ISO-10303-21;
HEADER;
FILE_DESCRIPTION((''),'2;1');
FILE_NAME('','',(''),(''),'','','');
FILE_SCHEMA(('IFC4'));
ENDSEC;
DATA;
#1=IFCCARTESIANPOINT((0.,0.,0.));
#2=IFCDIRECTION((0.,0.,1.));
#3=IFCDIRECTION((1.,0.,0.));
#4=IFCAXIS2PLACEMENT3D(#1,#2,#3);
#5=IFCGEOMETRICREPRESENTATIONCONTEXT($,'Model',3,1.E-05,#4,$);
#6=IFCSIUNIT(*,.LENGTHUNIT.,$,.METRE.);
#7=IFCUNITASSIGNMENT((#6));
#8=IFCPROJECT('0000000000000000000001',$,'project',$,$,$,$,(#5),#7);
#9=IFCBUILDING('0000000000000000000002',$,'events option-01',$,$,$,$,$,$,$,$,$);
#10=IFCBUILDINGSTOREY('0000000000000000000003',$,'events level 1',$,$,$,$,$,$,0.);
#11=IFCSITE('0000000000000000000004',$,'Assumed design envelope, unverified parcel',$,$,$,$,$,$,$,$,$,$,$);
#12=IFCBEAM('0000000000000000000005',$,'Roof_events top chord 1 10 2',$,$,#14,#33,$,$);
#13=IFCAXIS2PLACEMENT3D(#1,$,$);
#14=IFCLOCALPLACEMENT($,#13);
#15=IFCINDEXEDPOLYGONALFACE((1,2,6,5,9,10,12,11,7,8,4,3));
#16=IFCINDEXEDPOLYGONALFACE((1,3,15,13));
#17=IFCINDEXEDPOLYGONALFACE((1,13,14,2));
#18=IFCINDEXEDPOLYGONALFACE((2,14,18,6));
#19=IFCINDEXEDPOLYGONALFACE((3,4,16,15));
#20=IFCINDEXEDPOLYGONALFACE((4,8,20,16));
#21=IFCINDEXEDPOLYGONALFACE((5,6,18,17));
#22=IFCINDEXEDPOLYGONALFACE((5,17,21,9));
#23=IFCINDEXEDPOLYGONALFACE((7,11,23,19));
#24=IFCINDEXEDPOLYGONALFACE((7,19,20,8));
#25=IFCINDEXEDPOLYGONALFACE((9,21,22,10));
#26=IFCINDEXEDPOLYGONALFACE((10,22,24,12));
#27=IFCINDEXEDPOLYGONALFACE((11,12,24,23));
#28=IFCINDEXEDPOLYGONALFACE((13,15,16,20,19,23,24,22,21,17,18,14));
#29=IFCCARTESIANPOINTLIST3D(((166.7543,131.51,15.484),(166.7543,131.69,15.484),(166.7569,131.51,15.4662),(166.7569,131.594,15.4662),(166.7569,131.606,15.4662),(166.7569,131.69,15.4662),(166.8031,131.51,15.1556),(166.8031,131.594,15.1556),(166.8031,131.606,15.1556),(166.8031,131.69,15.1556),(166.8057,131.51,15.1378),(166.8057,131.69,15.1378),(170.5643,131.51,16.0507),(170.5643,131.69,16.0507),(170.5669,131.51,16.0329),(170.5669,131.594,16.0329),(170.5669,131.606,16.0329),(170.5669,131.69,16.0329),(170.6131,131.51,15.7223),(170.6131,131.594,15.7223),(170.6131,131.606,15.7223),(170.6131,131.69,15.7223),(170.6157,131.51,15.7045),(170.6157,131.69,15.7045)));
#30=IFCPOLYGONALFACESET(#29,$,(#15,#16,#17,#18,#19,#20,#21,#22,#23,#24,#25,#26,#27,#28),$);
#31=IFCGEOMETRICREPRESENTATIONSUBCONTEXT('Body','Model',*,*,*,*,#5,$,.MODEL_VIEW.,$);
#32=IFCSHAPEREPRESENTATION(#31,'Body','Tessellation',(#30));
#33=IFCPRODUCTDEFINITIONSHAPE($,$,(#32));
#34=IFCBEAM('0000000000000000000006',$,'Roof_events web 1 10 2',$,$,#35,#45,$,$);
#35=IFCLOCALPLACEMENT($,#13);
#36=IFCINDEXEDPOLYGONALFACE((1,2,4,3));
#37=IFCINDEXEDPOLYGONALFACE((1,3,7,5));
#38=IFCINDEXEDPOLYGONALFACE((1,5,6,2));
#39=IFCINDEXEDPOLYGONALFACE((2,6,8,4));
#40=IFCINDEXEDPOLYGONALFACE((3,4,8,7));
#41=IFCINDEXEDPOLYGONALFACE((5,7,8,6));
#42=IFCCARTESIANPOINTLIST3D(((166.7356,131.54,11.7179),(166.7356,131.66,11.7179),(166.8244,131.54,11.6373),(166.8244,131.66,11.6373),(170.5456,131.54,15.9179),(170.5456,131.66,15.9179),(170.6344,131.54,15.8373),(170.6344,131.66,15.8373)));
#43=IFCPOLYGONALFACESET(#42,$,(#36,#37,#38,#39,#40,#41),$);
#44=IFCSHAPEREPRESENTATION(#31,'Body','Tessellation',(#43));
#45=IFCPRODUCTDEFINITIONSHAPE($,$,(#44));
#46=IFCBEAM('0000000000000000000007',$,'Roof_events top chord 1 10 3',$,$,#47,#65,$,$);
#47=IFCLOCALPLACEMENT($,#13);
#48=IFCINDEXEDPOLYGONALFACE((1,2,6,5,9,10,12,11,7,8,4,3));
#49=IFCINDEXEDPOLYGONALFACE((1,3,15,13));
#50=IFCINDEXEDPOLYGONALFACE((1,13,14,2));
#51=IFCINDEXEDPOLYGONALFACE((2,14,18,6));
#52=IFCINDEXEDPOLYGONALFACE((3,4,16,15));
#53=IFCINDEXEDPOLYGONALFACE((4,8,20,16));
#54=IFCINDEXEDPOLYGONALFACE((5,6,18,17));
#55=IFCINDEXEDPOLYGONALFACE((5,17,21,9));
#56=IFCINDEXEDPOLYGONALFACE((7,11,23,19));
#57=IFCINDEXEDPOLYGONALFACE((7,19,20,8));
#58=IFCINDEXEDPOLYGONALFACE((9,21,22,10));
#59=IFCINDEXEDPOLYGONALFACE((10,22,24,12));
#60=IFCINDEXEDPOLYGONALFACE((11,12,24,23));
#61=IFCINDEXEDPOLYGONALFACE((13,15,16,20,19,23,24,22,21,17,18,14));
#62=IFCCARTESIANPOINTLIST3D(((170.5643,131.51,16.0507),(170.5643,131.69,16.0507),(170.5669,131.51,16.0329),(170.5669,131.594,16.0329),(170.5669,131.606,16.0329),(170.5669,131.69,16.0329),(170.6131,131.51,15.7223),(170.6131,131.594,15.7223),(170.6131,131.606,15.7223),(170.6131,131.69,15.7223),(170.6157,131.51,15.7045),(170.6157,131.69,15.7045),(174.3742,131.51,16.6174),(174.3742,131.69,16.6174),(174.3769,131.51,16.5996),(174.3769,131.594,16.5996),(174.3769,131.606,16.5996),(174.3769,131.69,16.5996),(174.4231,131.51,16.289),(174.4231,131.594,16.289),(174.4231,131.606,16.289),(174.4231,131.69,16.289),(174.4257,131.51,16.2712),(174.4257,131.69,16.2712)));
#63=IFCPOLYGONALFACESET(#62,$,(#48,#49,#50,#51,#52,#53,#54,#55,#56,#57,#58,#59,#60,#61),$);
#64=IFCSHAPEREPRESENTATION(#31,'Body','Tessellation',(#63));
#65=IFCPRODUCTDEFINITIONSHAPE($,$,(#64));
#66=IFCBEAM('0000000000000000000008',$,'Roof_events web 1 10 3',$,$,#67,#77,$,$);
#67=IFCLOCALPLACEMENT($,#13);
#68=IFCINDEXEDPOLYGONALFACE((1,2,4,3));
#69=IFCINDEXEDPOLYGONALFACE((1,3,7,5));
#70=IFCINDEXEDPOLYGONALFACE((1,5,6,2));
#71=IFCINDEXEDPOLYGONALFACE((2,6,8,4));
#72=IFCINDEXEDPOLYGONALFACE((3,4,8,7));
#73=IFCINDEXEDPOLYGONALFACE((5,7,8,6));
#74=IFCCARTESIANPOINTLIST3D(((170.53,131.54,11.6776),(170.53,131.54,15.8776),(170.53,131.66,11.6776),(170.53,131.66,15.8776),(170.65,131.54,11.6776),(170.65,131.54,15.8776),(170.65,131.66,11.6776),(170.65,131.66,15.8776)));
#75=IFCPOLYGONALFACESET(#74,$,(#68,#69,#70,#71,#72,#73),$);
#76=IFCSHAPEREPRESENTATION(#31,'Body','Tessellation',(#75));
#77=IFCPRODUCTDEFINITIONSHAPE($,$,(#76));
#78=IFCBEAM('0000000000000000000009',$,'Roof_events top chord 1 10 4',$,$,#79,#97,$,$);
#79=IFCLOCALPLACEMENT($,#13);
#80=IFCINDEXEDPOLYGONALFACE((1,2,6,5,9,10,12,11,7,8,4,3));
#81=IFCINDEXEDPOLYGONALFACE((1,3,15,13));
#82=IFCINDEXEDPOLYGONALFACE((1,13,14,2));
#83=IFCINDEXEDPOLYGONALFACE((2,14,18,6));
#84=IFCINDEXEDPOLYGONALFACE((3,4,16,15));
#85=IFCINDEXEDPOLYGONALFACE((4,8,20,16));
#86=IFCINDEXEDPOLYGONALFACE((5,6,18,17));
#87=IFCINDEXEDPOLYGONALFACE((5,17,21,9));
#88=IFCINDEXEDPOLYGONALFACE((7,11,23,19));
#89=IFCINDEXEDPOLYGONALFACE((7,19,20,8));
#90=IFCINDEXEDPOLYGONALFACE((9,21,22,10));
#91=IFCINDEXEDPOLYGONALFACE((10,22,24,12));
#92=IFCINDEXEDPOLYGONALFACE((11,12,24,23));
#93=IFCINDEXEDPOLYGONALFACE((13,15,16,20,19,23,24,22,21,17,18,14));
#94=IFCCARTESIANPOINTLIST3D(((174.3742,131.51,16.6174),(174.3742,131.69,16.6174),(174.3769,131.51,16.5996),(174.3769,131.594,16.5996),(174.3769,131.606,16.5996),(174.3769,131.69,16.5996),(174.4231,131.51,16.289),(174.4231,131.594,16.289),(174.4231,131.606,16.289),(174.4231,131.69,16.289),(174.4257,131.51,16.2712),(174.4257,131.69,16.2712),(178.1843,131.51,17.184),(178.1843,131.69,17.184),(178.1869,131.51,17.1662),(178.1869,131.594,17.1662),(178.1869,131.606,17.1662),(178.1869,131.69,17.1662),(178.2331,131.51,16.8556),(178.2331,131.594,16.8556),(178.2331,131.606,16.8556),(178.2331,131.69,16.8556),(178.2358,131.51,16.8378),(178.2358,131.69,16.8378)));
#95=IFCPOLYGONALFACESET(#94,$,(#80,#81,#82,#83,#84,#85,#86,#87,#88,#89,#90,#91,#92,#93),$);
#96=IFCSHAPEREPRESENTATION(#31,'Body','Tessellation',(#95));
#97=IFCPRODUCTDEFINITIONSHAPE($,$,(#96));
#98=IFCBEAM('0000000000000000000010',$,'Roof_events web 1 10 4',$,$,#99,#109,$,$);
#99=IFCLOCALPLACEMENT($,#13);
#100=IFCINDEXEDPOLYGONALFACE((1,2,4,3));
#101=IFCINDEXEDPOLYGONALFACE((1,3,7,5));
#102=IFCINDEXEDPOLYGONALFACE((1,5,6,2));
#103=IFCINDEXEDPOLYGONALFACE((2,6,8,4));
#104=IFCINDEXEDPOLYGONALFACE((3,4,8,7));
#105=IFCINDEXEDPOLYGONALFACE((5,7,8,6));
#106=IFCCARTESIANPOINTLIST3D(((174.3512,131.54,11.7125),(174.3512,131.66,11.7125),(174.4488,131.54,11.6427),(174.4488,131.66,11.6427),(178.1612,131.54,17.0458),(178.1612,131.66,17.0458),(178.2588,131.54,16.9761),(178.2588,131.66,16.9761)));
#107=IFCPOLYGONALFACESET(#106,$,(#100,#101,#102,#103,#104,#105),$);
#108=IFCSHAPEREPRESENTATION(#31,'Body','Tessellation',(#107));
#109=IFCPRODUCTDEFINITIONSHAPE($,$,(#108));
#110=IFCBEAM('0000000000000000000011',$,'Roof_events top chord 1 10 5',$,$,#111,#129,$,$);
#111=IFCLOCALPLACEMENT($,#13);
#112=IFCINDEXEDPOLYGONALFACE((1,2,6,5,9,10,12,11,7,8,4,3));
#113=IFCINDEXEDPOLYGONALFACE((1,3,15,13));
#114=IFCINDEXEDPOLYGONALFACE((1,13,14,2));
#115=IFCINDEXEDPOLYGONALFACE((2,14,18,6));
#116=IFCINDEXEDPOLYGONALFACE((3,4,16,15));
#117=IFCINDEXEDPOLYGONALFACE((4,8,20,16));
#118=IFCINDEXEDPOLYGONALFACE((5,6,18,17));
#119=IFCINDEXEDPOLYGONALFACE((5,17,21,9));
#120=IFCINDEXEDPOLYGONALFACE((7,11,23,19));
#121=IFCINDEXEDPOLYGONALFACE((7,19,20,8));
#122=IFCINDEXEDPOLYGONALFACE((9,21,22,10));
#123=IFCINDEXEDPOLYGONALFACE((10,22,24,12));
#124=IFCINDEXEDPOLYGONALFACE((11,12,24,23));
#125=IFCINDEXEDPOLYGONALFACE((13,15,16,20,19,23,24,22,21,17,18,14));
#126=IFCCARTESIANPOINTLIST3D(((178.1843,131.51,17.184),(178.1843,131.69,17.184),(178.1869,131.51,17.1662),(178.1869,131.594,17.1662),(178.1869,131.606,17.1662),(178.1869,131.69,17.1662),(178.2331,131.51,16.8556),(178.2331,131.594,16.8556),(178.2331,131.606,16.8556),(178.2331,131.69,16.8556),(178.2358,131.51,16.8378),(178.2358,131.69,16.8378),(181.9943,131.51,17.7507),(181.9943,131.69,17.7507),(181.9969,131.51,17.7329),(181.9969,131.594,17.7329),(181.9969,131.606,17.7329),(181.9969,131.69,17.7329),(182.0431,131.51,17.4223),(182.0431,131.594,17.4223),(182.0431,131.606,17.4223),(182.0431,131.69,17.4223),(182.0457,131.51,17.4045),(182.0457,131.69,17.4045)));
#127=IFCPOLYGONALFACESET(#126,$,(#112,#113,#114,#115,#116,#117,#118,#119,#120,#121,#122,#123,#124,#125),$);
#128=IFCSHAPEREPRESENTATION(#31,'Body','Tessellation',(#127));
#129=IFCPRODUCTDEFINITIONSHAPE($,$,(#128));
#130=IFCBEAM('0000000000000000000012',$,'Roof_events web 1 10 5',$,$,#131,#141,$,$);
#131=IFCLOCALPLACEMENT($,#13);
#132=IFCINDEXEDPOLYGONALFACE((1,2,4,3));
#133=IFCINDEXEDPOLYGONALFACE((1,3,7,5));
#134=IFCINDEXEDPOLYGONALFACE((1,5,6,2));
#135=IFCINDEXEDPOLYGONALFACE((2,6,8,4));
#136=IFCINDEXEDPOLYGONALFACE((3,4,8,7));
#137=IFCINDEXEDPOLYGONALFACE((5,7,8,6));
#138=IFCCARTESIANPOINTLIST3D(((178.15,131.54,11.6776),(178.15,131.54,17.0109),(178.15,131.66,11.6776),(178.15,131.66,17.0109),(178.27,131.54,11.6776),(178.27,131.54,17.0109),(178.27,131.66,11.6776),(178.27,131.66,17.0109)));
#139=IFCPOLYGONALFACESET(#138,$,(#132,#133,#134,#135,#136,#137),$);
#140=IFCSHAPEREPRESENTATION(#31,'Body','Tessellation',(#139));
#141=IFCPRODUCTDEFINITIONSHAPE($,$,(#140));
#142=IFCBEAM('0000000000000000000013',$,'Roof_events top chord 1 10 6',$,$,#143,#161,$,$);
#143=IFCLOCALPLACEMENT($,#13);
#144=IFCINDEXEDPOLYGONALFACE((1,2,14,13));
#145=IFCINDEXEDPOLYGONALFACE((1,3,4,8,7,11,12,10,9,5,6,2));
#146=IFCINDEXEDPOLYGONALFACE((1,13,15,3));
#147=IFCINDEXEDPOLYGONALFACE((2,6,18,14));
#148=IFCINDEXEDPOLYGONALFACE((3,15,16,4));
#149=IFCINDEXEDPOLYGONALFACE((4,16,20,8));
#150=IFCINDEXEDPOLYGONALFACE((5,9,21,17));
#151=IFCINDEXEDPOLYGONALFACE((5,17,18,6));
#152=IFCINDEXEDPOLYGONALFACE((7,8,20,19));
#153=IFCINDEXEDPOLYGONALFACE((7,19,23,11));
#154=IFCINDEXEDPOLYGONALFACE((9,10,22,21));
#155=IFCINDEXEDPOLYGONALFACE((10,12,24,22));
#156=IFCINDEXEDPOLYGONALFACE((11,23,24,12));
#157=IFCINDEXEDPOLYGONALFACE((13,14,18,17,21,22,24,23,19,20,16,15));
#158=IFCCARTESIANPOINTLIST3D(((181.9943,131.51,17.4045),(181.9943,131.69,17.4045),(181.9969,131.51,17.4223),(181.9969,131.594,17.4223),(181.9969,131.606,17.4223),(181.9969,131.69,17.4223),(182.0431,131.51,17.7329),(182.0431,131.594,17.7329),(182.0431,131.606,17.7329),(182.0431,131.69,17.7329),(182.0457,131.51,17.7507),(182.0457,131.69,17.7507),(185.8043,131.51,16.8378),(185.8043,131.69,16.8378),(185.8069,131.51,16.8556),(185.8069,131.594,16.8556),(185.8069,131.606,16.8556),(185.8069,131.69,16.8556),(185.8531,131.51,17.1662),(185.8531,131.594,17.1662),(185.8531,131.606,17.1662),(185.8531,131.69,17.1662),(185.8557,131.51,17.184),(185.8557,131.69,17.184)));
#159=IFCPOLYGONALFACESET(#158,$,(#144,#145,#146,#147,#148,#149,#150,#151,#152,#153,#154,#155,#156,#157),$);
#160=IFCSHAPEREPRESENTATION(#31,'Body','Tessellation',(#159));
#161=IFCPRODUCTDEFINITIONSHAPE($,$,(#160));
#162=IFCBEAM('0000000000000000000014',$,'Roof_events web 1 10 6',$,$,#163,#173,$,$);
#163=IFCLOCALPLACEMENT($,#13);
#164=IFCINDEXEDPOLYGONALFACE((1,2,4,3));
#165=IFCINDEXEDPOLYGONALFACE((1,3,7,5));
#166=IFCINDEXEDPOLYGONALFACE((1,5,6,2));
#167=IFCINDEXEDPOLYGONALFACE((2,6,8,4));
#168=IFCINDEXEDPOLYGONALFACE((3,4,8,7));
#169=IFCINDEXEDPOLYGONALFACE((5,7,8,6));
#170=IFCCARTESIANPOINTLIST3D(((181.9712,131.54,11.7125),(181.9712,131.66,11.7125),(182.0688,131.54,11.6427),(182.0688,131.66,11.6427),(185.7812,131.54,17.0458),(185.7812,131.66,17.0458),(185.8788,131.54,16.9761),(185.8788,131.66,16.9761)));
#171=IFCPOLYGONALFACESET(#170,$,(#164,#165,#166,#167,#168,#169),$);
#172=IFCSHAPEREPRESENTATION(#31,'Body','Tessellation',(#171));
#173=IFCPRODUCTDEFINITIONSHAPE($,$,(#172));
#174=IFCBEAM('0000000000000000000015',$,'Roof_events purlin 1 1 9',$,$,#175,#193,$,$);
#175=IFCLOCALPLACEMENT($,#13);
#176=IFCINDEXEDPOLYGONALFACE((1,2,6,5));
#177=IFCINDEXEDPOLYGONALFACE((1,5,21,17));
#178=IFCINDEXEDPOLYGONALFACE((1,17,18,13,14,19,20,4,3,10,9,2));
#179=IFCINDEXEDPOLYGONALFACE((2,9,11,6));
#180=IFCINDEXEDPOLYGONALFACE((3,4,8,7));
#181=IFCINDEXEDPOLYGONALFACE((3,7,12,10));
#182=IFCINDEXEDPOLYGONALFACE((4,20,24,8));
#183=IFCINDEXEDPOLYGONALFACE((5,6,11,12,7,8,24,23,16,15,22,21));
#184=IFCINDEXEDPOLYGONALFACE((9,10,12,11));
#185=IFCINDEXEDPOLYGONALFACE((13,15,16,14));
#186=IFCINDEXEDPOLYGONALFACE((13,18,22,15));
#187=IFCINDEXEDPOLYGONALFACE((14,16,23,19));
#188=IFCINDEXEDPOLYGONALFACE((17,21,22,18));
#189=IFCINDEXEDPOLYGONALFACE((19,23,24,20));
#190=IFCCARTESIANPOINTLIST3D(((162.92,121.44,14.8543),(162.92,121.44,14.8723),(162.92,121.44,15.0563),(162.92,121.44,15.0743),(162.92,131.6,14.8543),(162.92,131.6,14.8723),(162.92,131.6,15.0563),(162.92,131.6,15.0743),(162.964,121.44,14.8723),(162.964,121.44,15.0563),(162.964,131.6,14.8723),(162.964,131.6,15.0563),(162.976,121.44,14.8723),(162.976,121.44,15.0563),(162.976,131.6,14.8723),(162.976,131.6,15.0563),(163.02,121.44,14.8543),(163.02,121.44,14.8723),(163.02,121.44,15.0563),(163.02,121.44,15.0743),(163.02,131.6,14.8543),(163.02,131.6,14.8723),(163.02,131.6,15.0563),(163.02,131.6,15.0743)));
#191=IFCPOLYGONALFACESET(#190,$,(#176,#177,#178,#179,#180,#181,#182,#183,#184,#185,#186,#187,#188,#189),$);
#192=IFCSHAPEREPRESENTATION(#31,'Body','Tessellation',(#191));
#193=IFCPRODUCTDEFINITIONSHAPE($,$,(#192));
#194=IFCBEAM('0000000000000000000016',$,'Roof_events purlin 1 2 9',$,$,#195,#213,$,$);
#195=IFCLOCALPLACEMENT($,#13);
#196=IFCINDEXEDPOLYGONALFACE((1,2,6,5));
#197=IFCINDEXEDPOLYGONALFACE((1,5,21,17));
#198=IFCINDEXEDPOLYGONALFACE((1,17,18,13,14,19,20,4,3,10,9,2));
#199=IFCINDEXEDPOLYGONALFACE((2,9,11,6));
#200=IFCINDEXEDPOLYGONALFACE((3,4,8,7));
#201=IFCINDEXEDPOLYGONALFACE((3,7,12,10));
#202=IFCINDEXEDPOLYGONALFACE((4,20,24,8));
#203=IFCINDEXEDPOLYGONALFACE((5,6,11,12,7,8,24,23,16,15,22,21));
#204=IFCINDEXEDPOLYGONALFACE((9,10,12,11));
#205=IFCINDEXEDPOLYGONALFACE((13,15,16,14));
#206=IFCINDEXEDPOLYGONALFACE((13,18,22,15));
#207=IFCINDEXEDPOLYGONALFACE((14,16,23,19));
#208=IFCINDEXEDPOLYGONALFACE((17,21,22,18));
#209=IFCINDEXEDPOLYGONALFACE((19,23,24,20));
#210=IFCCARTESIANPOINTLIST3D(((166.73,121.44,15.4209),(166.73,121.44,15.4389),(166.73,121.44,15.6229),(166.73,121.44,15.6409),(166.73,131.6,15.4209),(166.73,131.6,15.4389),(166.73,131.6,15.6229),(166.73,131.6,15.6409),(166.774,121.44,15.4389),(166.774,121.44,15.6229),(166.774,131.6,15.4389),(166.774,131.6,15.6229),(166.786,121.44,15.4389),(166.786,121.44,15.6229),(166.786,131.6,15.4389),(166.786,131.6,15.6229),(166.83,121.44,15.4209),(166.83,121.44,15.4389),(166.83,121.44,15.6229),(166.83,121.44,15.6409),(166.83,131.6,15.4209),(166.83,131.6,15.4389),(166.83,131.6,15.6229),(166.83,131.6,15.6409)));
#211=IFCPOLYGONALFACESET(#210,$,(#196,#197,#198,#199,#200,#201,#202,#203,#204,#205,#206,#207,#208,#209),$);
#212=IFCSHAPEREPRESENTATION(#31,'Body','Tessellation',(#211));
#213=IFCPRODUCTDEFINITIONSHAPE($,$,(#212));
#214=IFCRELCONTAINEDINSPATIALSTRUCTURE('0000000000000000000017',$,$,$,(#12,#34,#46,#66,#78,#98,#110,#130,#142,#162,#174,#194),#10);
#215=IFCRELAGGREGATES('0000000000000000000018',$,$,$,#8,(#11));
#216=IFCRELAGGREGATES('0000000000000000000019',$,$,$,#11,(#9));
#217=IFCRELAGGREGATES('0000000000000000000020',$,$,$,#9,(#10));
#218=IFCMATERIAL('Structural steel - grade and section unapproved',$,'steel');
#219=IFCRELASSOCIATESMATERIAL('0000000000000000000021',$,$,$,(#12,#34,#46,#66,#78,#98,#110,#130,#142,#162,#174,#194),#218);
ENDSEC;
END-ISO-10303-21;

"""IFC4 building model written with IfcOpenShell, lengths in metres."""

from ifc_helpers import new_model, si_unit, frame, origin_with_axes, place, context, subcontext, project, spatial, rectangle, i_section, extrude, material, element, save


model = new_model("IFC4")

# Units and contexts
model_context = context("Model", 3, precision=1e-05, world=origin_with_axes())
body_context = subcontext(model_context, "Body", "Model", "MODEL_VIEW")
ifc_project = project(units=[si_unit("LENGTHUNIT", "METRE")], contexts=[model_context])

# Site, building, storey
site = spatial("IfcSite", under=ifc_project, Name="Assumed design envelope, unverified parcel")
building = spatial("IfcBuilding", under=site, Name="events option-01")
storey = spatial("IfcBuildingStorey", under=building, Name="events level 1", Elevation=0.0)

# Beams
ifc_material_1 = material(Name="Structural steel - grade and section unapproved", Category="steel")
beam_1_placement = place(None, frame((166.78, 131.6, 15.3109), z_axis=(0.98912, 0.0, 0.147113), x_axis=(0.0, 1.0, 0.0)))
element("IfcBeam", 1, at=beam_1_placement, inside=storey, material=ifc_material_1, Name="Roof_events top chord 1 10 2", context=body_context, shape_type="SweptSolid", body=[
    extrude(i_section(OverallWidth=0.18, OverallDepth=0.35, WebThickness=0.012, FlangeThickness=0.018, FilletRadius=0.0), origin_with_axes(), (0.0, 0.0, 1.0), 3.8519),
])
beam_2_placement = place(None, frame((166.78, 131.6, 11.6776), z_axis=(0.671882, 0.0, 0.740658), x_axis=(0.0, 1.0, 0.0)))
element("IfcBeam", 2, at=beam_2_placement, inside=storey, material=ifc_material_1, Name="Roof_events web 1 10 2", context=body_context, shape_type="SweptSolid", body=[
    extrude(rectangle(XDim=0.12, YDim=0.12), origin_with_axes(), (0.0, 0.0, 1.0), 5.6706),
])
beam_3_placement = place(None, frame((170.59, 131.6, 15.8776), z_axis=(0.98912, 0.0, 0.147113), x_axis=(0.0, 1.0, 0.0)))
element("IfcBeam", 3, at=beam_3_placement, inside=storey, material=ifc_material_1, Name="Roof_events top chord 1 10 3", context=body_context, shape_type="SweptSolid", body=[
    extrude(i_section(OverallWidth=0.18, OverallDepth=0.35, WebThickness=0.012, FlangeThickness=0.018, FilletRadius=0.0), origin_with_axes(), (0.0, 0.0, 1.0), 3.8519),
])
beam_4_placement = place(None, frame((170.59, 131.6, 11.6776), z_axis=(0.0, 0.0, 1.0), x_axis=(-1.0, 0.0, 0.0)))
element("IfcBeam", 4, at=beam_4_placement, inside=storey, material=ifc_material_1, Name="Roof_events web 1 10 3", context=body_context, shape_type="SweptSolid", body=[
    extrude(rectangle(XDim=0.12, YDim=0.12), origin_with_axes(), (0.0, 0.0, 1.0), 4.2),
])
beam_5_placement = place(None, frame((174.4, 131.6, 16.4443), z_axis=(0.98912, 0.0, 0.147112), x_axis=(0.0, 1.0, 0.0)))
element("IfcBeam", 5, at=beam_5_placement, inside=storey, material=ifc_material_1, Name="Roof_events top chord 1 10 4", context=body_context, shape_type="SweptSolid", body=[
    extrude(i_section(OverallWidth=0.18, OverallDepth=0.35, WebThickness=0.012, FlangeThickness=0.018, FilletRadius=0.0), origin_with_axes(), (0.0, 0.0, 1.0), 3.8519),
])
beam_6_placement = place(None, frame((174.4, 131.6, 11.6776), z_axis=(0.581288, 0.0, 0.813698), x_axis=(0.0, 1.0, 0.0)))
element("IfcBeam", 6, at=beam_6_placement, inside=storey, material=ifc_material_1, Name="Roof_events web 1 10 4", context=body_context, shape_type="SweptSolid", body=[
    extrude(rectangle(XDim=0.12, YDim=0.12), origin_with_axes(), (0.0, 0.0, 1.0), 6.5544),
])
beam_7_placement = place(None, frame((178.21, 131.6, 17.0109), z_axis=(0.98912, 0.0, 0.147113), x_axis=(0.0, 1.0, 0.0)))
element("IfcBeam", 7, at=beam_7_placement, inside=storey, material=ifc_material_1, Name="Roof_events top chord 1 10 5", context=body_context, shape_type="SweptSolid", body=[
    extrude(i_section(OverallWidth=0.18, OverallDepth=0.35, WebThickness=0.012, FlangeThickness=0.018, FilletRadius=0.0), origin_with_axes(), (0.0, 0.0, 1.0), 3.8519),
])
beam_8_placement = place(None, frame((178.21, 131.6, 11.6776), z_axis=(0.0, 0.0, 1.0), x_axis=(-1.0, 0.0, 0.0)))
element("IfcBeam", 8, at=beam_8_placement, inside=storey, material=ifc_material_1, Name="Roof_events web 1 10 5", context=body_context, shape_type="SweptSolid", body=[
    extrude(rectangle(XDim=0.12, YDim=0.12), origin_with_axes(), (0.0, 0.0, 1.0), 5.3333),
])
beam_9_placement = place(None, frame((182.02, 131.6, 17.5776), z_axis=(0.98912, 0.0, -0.147113), x_axis=(0.0, 1.0, 0.0)))
element("IfcBeam", 9, at=beam_9_placement, inside=storey, material=ifc_material_1, Name="Roof_events top chord 1 10 6", context=body_context, shape_type="SweptSolid", body=[
    extrude(i_section(OverallWidth=0.18, OverallDepth=0.35, WebThickness=0.012, FlangeThickness=0.018, FilletRadius=0.0), origin_with_axes(), (0.0, 0.0, 1.0), 3.8519),
])
beam_10_placement = place(None, frame((182.02, 131.6, 11.6776), z_axis=(0.581286, 0.0, 0.813699), x_axis=(0.0, 1.0, 0.0)))
element("IfcBeam", 10, at=beam_10_placement, inside=storey, material=ifc_material_1, Name="Roof_events web 1 10 6", context=body_context, shape_type="SweptSolid", body=[
    extrude(rectangle(XDim=0.12, YDim=0.12), origin_with_axes(), (0.0, 0.0, 1.0), 6.5544),
])
for number, where, z_axis, x_axis, name in (
    (11, (162.97, 121.44, 14.9643), (0.0, 1.0, 0.0), (-1.0, 0.0, 0.0), "Roof_events purlin 1 1 9"),
    (12, (166.78, 121.44, 15.5309), (0.0, 1.0, 0.0), (-1.0, 0.0, 0.0), "Roof_events purlin 1 2 9"),
):
    element("IfcBeam", number, at=place(None, frame(where, z_axis=z_axis, x_axis=x_axis)), inside=storey, material=ifc_material_1, Name=name, context=body_context, shape_type="SweptSolid", body=[
        extrude(i_section(OverallWidth=0.1, OverallDepth=0.22, WebThickness=0.012, FlangeThickness=0.018, FilletRadius=0.0), origin_with_axes(), (0.0, 0.0, 1.0), 10.16),
    ])

save(model, "model.ifc")
